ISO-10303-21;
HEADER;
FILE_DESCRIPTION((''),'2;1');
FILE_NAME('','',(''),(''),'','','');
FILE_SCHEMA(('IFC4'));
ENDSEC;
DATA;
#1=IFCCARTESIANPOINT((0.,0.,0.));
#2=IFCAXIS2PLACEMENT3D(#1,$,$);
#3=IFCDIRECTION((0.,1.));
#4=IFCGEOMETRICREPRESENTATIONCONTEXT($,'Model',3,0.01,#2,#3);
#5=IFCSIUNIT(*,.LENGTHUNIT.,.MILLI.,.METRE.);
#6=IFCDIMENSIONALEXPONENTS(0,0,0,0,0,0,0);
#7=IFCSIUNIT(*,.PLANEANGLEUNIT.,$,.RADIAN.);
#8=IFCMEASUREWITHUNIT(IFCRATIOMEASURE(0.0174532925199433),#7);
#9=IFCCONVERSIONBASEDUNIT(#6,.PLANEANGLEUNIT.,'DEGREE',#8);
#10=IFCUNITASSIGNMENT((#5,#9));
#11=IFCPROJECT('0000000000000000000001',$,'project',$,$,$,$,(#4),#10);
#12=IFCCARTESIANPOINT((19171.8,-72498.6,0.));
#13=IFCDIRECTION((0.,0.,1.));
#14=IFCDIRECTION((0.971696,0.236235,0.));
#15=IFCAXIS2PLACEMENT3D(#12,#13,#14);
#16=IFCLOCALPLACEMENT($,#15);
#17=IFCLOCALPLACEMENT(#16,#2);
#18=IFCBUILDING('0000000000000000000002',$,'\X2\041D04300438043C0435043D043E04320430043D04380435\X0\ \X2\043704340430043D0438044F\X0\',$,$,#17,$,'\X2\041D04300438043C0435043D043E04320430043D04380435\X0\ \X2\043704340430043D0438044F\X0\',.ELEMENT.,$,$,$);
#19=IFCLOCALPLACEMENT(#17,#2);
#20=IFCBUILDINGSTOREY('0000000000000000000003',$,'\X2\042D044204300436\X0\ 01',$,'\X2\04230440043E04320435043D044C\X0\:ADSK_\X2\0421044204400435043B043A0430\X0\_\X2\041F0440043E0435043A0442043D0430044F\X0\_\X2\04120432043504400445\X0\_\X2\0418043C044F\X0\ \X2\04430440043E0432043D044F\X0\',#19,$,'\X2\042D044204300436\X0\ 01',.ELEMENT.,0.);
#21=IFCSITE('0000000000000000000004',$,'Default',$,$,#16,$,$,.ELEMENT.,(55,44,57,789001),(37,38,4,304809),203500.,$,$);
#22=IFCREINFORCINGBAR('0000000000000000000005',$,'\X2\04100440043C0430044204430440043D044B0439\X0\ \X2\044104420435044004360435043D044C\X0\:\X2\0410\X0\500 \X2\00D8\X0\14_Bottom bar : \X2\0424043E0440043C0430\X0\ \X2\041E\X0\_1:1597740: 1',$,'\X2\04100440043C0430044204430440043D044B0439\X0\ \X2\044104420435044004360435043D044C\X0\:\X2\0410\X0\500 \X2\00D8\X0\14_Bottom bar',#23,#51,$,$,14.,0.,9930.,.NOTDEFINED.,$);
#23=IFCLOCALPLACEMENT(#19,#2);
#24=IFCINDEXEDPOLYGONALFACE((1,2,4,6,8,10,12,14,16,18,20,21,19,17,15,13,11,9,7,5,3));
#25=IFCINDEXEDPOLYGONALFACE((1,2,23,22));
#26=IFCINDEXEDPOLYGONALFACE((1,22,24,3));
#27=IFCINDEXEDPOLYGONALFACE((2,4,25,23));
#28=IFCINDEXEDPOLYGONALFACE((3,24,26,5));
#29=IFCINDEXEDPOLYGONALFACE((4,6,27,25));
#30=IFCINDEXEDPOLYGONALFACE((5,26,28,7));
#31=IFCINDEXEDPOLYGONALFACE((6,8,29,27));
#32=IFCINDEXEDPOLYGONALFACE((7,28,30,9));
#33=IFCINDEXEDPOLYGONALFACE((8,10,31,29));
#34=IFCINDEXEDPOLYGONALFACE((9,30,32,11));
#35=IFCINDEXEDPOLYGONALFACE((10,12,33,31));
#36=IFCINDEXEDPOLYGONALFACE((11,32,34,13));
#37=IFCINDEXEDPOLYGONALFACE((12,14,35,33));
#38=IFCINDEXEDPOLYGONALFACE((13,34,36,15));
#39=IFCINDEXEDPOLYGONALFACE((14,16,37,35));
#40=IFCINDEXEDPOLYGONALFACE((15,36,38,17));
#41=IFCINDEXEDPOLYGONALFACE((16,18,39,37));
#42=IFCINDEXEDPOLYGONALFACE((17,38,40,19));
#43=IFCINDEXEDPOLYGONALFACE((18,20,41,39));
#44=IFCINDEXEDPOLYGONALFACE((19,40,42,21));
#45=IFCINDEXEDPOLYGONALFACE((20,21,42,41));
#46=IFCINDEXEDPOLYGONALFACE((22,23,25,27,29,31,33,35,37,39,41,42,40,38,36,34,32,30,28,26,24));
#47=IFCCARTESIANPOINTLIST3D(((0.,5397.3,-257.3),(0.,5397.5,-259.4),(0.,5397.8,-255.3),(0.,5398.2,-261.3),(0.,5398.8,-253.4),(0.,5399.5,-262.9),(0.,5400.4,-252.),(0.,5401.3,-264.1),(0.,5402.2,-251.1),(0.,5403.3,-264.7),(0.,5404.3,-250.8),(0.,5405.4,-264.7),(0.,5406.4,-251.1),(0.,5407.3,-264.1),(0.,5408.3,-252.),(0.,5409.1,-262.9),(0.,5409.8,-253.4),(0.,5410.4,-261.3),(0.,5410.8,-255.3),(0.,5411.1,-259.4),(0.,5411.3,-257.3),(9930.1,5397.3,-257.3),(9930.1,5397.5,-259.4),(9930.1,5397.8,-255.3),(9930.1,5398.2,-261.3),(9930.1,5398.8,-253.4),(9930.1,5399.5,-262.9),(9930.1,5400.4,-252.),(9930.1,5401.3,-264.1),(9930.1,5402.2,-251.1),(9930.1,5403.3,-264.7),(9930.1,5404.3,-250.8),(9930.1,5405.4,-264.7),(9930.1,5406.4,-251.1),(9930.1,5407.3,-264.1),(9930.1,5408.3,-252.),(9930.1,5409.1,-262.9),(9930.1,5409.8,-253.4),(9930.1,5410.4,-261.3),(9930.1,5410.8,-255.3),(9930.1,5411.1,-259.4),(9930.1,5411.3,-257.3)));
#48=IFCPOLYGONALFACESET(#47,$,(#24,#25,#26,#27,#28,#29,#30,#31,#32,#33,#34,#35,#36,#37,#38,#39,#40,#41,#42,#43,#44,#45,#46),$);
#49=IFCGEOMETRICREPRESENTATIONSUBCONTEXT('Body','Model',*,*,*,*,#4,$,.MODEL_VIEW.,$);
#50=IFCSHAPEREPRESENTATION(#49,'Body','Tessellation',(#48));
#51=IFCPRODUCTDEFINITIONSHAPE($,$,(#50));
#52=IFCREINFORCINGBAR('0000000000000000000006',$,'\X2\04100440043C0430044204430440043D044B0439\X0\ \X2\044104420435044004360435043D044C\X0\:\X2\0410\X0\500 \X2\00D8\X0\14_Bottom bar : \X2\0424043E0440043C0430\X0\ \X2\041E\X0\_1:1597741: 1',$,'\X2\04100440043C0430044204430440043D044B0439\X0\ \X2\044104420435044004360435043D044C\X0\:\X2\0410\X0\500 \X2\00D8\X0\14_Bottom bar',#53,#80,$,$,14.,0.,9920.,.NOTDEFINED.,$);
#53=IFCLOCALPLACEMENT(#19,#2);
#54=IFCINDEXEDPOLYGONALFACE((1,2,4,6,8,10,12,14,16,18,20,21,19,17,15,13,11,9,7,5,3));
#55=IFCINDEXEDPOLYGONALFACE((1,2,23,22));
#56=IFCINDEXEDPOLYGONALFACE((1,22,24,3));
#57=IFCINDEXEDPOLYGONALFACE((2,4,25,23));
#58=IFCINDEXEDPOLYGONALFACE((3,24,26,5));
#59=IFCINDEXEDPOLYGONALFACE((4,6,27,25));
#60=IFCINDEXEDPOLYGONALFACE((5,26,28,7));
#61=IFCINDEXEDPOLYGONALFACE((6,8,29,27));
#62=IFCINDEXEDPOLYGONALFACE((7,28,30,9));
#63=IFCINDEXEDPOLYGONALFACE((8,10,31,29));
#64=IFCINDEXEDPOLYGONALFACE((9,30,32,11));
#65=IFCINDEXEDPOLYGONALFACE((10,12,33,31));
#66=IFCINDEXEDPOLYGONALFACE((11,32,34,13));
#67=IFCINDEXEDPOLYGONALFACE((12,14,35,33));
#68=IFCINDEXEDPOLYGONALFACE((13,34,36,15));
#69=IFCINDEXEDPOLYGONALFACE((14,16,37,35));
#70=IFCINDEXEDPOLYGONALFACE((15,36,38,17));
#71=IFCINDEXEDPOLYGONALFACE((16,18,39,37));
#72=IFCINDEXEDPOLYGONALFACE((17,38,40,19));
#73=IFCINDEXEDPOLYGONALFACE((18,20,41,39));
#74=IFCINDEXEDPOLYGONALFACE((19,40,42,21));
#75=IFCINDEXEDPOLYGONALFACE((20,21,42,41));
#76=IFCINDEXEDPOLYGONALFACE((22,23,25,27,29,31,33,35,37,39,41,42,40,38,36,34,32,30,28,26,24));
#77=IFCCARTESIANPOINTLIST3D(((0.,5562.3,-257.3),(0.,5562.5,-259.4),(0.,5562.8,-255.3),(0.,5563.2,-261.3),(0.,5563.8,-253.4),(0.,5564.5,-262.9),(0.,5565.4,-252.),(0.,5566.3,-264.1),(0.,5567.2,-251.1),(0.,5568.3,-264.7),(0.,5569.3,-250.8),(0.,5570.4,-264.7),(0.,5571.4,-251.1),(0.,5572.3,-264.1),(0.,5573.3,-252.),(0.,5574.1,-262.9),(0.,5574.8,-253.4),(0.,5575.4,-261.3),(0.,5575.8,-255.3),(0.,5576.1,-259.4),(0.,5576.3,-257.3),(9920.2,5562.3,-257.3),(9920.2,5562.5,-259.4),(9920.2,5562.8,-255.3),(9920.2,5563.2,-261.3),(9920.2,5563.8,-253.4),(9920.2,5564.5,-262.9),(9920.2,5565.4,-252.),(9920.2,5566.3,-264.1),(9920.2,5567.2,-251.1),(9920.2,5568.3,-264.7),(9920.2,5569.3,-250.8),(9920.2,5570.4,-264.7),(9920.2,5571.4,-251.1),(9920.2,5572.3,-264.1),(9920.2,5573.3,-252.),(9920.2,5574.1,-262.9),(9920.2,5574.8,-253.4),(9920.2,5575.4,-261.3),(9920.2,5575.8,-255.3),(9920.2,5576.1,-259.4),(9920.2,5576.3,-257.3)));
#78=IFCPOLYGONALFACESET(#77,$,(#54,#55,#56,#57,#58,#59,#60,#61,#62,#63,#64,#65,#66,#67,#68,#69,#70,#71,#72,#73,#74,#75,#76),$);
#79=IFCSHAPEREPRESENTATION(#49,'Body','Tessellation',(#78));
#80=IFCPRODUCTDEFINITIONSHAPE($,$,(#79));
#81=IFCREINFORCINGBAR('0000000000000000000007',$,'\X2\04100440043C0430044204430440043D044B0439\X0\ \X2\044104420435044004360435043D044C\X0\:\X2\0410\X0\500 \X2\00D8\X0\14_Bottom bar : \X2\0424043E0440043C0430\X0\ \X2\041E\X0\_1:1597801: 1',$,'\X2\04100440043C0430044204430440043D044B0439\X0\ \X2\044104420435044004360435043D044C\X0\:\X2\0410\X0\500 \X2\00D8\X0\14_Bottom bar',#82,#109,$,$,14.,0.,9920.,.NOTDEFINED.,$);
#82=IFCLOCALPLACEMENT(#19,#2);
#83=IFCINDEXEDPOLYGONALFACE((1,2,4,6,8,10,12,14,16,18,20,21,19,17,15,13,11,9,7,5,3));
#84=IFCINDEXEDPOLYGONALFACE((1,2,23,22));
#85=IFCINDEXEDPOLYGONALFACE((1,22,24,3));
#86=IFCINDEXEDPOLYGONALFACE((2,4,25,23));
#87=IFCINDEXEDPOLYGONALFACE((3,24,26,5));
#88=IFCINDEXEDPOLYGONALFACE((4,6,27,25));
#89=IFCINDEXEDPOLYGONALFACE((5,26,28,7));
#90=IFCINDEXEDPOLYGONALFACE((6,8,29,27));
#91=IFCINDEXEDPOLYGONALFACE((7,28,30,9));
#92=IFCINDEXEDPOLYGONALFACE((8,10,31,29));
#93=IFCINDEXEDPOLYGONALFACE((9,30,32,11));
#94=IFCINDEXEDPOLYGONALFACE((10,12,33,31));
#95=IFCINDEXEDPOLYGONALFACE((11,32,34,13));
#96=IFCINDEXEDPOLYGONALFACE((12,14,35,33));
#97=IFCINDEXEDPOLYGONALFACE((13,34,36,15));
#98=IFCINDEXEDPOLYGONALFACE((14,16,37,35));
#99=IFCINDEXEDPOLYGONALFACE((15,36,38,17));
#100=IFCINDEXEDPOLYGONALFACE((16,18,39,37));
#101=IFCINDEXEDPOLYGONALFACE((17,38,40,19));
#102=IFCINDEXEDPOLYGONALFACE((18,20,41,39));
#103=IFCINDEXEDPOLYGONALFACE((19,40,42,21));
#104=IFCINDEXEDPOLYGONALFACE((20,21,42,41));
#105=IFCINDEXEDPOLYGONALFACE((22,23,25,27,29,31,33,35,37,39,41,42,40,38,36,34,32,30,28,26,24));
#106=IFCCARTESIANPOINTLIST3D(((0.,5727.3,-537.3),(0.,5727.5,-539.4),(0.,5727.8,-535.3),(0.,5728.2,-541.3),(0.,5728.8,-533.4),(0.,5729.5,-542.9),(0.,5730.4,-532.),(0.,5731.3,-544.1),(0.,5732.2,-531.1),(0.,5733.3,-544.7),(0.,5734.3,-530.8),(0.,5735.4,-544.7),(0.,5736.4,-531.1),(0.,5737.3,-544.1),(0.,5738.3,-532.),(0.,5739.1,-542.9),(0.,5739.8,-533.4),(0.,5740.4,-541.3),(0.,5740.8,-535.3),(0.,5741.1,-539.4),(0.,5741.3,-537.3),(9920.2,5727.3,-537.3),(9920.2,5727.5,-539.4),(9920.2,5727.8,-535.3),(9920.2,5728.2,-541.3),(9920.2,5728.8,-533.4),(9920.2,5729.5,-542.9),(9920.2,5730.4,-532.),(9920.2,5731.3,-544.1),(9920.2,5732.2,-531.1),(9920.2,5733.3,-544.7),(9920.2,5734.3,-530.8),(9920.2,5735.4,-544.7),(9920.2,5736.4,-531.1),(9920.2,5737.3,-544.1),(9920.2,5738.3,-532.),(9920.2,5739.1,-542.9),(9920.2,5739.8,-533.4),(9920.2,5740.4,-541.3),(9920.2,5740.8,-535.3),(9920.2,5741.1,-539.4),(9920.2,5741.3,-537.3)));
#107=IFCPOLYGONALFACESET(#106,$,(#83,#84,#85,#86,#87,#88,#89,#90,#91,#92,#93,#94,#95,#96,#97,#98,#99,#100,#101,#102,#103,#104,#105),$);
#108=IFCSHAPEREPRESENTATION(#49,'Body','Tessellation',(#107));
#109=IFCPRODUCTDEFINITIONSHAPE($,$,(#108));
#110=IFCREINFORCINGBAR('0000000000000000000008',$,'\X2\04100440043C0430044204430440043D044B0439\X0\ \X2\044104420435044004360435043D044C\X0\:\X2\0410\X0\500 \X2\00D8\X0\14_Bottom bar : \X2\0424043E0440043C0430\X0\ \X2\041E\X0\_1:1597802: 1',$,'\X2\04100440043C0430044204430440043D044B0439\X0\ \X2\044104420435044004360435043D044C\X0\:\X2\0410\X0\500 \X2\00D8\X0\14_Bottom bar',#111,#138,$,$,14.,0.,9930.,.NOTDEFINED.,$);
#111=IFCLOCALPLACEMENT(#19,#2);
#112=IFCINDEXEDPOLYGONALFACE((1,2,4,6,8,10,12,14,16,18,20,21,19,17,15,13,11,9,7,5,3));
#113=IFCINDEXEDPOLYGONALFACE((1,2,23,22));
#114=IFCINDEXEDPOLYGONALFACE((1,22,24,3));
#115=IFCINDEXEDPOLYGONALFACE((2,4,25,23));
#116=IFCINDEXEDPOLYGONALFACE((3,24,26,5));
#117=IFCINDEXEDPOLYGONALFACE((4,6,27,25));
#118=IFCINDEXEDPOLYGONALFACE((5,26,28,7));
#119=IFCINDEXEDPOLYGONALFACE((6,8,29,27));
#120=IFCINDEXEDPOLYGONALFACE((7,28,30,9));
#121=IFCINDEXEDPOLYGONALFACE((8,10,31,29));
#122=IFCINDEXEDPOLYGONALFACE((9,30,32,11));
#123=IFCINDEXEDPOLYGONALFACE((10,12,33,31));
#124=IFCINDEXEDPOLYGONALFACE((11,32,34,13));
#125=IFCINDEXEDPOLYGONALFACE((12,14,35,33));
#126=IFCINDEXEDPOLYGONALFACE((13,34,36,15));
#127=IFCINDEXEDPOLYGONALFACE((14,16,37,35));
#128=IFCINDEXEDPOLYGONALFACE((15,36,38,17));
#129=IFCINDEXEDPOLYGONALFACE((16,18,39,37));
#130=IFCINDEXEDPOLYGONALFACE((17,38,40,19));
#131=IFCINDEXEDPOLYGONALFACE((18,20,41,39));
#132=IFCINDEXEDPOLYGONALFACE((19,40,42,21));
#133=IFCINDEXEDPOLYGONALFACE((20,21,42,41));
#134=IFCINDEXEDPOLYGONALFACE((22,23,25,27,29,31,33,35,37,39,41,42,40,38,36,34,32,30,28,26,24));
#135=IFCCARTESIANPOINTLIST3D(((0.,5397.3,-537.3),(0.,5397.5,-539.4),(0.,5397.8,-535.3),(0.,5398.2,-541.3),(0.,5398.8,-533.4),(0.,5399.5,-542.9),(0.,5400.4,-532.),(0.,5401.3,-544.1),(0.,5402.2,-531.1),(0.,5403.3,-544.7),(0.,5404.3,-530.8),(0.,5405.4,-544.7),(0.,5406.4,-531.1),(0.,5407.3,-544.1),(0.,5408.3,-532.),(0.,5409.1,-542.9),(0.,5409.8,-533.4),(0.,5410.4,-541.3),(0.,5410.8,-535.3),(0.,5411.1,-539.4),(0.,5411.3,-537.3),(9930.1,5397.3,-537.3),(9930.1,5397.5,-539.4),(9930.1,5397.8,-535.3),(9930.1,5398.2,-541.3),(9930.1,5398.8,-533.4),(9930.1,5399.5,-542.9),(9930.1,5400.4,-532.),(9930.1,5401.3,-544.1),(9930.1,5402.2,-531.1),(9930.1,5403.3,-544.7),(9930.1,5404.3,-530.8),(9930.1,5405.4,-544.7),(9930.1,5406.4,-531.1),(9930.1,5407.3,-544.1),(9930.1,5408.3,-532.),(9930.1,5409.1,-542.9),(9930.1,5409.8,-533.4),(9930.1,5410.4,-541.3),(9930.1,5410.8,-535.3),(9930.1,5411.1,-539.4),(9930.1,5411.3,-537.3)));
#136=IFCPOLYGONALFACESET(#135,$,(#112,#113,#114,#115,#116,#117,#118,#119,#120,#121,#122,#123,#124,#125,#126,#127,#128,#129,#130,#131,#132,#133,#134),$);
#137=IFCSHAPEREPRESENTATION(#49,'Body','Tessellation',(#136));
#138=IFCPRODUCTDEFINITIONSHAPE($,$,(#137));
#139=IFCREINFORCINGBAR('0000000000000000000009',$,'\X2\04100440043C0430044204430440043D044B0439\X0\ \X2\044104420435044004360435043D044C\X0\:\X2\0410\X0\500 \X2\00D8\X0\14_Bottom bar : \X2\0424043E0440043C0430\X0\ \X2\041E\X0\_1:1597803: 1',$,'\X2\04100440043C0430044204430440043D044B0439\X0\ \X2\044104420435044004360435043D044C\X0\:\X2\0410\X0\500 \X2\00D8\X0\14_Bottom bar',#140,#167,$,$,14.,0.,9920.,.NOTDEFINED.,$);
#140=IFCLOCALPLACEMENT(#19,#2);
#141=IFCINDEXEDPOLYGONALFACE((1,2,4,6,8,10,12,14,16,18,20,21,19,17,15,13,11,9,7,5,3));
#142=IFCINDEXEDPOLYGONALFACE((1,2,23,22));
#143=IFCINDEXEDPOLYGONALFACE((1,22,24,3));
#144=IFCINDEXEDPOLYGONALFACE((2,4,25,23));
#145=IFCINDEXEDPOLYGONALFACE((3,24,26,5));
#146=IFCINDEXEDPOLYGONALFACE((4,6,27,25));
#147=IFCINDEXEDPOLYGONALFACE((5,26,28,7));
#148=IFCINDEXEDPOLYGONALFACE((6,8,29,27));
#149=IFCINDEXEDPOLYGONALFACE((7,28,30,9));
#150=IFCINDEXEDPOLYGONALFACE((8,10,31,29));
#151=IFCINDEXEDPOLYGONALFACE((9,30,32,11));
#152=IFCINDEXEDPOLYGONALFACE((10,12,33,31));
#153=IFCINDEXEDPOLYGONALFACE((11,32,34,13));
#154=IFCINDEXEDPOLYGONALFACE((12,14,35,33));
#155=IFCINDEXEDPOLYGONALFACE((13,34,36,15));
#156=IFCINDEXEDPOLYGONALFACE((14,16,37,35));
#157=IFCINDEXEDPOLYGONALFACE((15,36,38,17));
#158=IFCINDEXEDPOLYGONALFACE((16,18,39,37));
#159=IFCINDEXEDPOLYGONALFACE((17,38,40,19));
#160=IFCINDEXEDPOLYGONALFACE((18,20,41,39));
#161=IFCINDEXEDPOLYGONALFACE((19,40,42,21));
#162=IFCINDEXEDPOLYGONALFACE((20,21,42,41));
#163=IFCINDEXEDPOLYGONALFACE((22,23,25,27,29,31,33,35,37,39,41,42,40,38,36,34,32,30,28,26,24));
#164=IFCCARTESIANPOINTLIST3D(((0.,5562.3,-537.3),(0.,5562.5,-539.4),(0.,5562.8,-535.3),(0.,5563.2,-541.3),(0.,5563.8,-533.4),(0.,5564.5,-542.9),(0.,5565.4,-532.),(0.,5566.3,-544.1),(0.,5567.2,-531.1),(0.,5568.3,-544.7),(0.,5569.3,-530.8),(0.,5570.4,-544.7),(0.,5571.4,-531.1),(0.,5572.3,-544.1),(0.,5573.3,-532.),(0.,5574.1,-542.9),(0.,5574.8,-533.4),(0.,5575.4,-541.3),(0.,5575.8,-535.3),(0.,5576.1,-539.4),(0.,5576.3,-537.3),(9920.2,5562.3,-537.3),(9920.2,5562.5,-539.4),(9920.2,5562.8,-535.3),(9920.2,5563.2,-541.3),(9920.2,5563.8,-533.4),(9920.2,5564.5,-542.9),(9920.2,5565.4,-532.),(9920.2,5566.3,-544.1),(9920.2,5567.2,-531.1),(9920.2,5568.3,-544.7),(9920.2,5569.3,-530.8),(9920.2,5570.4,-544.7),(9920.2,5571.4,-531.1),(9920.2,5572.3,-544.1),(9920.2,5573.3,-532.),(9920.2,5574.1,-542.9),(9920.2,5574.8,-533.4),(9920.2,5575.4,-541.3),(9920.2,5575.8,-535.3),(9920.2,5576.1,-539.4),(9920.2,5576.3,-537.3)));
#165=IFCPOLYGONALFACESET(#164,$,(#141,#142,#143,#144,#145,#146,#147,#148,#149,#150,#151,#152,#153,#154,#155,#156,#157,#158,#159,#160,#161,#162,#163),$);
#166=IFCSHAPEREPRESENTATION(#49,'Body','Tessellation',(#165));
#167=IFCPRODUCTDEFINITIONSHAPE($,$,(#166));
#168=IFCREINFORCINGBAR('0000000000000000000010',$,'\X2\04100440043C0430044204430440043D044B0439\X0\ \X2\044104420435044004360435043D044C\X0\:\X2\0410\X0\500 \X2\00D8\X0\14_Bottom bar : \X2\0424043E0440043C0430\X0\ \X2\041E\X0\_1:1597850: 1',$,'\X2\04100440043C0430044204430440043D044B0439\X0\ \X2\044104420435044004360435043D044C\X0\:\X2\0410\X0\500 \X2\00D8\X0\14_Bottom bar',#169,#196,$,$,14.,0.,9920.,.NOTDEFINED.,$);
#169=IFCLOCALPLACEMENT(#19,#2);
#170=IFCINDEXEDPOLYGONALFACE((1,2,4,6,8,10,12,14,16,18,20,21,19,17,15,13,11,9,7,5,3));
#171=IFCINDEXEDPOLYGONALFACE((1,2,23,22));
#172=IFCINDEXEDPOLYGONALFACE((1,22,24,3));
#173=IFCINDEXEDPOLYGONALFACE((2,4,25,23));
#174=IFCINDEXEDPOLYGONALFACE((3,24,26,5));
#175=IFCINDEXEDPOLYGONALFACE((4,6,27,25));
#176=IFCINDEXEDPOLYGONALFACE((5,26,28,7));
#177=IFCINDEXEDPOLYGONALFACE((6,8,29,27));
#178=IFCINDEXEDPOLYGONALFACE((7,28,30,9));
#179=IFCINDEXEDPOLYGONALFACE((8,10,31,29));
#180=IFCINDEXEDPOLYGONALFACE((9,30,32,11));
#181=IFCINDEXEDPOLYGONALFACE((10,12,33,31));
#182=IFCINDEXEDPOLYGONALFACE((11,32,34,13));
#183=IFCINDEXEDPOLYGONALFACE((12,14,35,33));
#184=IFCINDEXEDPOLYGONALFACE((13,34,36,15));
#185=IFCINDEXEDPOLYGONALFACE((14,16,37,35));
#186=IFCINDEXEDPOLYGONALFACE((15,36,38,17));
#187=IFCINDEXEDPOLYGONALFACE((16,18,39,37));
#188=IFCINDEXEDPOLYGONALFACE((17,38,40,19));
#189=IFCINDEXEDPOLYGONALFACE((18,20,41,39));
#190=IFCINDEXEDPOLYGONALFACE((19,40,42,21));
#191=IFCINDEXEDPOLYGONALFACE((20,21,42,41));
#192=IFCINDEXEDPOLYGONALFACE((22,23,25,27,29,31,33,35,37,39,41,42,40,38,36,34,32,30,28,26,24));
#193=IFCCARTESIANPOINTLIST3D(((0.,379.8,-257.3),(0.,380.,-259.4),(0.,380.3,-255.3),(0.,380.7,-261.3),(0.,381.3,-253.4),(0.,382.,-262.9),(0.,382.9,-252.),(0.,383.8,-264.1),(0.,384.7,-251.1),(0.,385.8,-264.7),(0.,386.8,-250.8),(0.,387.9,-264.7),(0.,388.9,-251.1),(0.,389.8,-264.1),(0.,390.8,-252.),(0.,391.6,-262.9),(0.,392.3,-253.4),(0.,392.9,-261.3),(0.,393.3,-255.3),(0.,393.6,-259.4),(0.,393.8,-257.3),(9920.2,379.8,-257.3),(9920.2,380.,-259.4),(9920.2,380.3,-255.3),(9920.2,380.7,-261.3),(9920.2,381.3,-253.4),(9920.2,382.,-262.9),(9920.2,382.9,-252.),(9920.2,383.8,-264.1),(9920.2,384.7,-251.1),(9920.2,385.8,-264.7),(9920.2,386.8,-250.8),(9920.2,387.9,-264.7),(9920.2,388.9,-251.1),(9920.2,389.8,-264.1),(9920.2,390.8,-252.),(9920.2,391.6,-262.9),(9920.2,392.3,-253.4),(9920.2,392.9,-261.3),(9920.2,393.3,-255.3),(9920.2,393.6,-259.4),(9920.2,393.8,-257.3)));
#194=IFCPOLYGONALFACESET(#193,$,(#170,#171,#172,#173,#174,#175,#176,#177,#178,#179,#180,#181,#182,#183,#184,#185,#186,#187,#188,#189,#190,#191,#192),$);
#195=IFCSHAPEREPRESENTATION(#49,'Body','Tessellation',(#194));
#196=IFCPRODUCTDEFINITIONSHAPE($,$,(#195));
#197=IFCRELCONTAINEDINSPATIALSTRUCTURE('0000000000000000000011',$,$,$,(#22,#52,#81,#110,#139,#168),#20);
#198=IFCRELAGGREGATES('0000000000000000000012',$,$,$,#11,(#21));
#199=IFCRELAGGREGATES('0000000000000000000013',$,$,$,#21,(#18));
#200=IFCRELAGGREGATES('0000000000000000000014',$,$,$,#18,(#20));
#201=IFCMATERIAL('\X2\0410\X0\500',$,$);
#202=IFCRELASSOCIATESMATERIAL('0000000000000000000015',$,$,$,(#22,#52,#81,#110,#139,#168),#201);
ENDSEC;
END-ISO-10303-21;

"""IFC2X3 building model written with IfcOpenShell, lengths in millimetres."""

from ifc_helpers import new_model, entity, si_unit, converted_unit, direction, frame, origin, place, context, subcontext, project, spatial, material, element, save


model = new_model("IFC2X3")

# Units and contexts
model_context = context("Model", 3, precision=0.01, world=origin(), true_north=direction((0.0, 1.0)))
body_context = subcontext(model_context, "Body", "Model", "MODEL_VIEW")
ifc_project = project(units=[si_unit("LENGTHUNIT", "METRE", prefix="MILLI"), converted_unit("PLANEANGLEUNIT", "DEGREE", entity("IfcRatioMeasure", 0.0174532925199433), si_unit("PLANEANGLEUNIT", "RADIAN"), dimensions=[0, 0, 0, 0, 0, 0, 0])], contexts=[model_context])

# Site, building, storey
site_placement = place(None, frame((19171.8, -72498.6, 0.0), z_axis=(0.0, 0.0, 1.0), x_axis=(0.971696, 0.236235, 0.0)))
site = spatial("IfcSite", under=ifc_project, at=site_placement, Name="Default", CompositionType="ELEMENT", RefLatitude=(55, 44, 57, 789001), RefLongitude=(37, 38, 4, 304809), RefElevation=203500.0)
building_placement = place(site_placement, origin())
building = spatial("IfcBuilding", under=site, at=building_placement, Name="Наименование здания", LongName="Наименование здания", CompositionType="ELEMENT")
storey_placement = place(building_placement, origin())
storey = spatial("IfcBuildingStorey", under=building, at=storey_placement, Name="Этаж 01", ObjectType="Уровень:ADSK_Стрелка_Проектная_Вверх_Имя уровня", LongName="Этаж 01", CompositionType="ELEMENT", Elevation=0.0)

# Reinforcing bars
ifc_material = material(Name="А500")
placement = place(storey_placement, origin())
element("IfcReinforcingBar", 1, at=placement, inside=storey, material=ifc_material, Name="Арматурный стержень:А500 Ø14_Bottom bar : Форма О_1:1597740: 1", ObjectType="Арматурный стержень:А500 Ø14_Bottom bar", BarLength=9930.0, BarRole="NOTDEFINED", CrossSectionArea=0.0, NominalDiameter=14.0, context=body_context, shape_type="AdvancedSweptSolid", body=[
    entity("IfcSweptDiskSolid", entity("IfcCompositeCurve", [entity("IfcCompositeCurveSegment", "CONTINUOUS", True, entity("IfcPolyline", [entity("IfcCartesianPoint", [0.0, 5404.3, -257.8]), entity("IfcCartesianPoint", [9930.1, 5404.3, -257.8])]))], False), 7.0, None, 0.0, 1.0),
])
element("IfcReinforcingBar", 2, at=placement, inside=storey, material=ifc_material, Name="Арматурный стержень:А500 Ø14_Bottom bar : Форма О_1:1597741: 1", ObjectType="Арматурный стержень:А500 Ø14_Bottom bar", BarLength=9920.0, BarRole="NOTDEFINED", CrossSectionArea=0.0, NominalDiameter=14.0, context=body_context, shape_type="AdvancedSweptSolid", body=[
    entity("IfcSweptDiskSolid", entity("IfcCompositeCurve", [entity("IfcCompositeCurveSegment", "CONTINUOUS", True, entity("IfcPolyline", [entity("IfcCartesianPoint", [0.0, 5569.3, -257.8]), entity("IfcCartesianPoint", [9920.2, 5569.3, -257.8])]))], False), 7.0, None, 0.0, 1.0),
])
element("IfcReinforcingBar", 3, at=placement, inside=storey, material=ifc_material, Name="Арматурный стержень:А500 Ø14_Bottom bar : Форма О_1:1597801: 1", ObjectType="Арматурный стержень:А500 Ø14_Bottom bar", BarLength=9920.0, BarRole="NOTDEFINED", CrossSectionArea=0.0, NominalDiameter=14.0, context=body_context, shape_type="AdvancedSweptSolid", body=[
    entity("IfcSweptDiskSolid", entity("IfcCompositeCurve", [entity("IfcCompositeCurveSegment", "CONTINUOUS", True, entity("IfcPolyline", [entity("IfcCartesianPoint", [0.0, 5734.3, -537.8]), entity("IfcCartesianPoint", [9920.2, 5734.3, -537.8])]))], False), 7.0, None, 0.0, 1.0),
])
element("IfcReinforcingBar", 4, at=placement, inside=storey, material=ifc_material, Name="Арматурный стержень:А500 Ø14_Bottom bar : Форма О_1:1597802: 1", ObjectType="Арматурный стержень:А500 Ø14_Bottom bar", BarLength=9930.0, BarRole="NOTDEFINED", CrossSectionArea=0.0, NominalDiameter=14.0, context=body_context, shape_type="AdvancedSweptSolid", body=[
    entity("IfcSweptDiskSolid", entity("IfcCompositeCurve", [entity("IfcCompositeCurveSegment", "CONTINUOUS", True, entity("IfcPolyline", [entity("IfcCartesianPoint", [0.0, 5404.3, -537.8]), entity("IfcCartesianPoint", [9930.1, 5404.3, -537.8])]))], False), 7.0, None, 0.0, 1.0),
])
element("IfcReinforcingBar", 5, at=placement, inside=storey, material=ifc_material, Name="Арматурный стержень:А500 Ø14_Bottom bar : Форма О_1:1597803: 1", ObjectType="Арматурный стержень:А500 Ø14_Bottom bar", BarLength=9920.0, BarRole="NOTDEFINED", CrossSectionArea=0.0, NominalDiameter=14.0, context=body_context, shape_type="AdvancedSweptSolid", body=[
    entity("IfcSweptDiskSolid", entity("IfcCompositeCurve", [entity("IfcCompositeCurveSegment", "CONTINUOUS", True, entity("IfcPolyline", [entity("IfcCartesianPoint", [0.0, 5569.3, -537.8]), entity("IfcCartesianPoint", [9920.2, 5569.3, -537.8])]))], False), 7.0, None, 0.0, 1.0),
])
element("IfcReinforcingBar", 6, at=placement, inside=storey, material=ifc_material, Name="Арматурный стержень:А500 Ø14_Bottom bar : Форма О_1:1597850: 1", ObjectType="Арматурный стержень:А500 Ø14_Bottom bar", BarLength=9920.0, BarRole="NOTDEFINED", CrossSectionArea=0.0, NominalDiameter=14.0, context=body_context, shape_type="AdvancedSweptSolid", body=[
    entity("IfcSweptDiskSolid", entity("IfcCompositeCurve", [entity("IfcCompositeCurveSegment", "CONTINUOUS", True, entity("IfcPolyline", [entity("IfcCartesianPoint", [0.0, 386.8, -257.8]), entity("IfcCartesianPoint", [9920.2, 386.8, -257.8])]))], False), 7.0, None, 0.0, 1.0),
])

save(model, "model.ifc")
